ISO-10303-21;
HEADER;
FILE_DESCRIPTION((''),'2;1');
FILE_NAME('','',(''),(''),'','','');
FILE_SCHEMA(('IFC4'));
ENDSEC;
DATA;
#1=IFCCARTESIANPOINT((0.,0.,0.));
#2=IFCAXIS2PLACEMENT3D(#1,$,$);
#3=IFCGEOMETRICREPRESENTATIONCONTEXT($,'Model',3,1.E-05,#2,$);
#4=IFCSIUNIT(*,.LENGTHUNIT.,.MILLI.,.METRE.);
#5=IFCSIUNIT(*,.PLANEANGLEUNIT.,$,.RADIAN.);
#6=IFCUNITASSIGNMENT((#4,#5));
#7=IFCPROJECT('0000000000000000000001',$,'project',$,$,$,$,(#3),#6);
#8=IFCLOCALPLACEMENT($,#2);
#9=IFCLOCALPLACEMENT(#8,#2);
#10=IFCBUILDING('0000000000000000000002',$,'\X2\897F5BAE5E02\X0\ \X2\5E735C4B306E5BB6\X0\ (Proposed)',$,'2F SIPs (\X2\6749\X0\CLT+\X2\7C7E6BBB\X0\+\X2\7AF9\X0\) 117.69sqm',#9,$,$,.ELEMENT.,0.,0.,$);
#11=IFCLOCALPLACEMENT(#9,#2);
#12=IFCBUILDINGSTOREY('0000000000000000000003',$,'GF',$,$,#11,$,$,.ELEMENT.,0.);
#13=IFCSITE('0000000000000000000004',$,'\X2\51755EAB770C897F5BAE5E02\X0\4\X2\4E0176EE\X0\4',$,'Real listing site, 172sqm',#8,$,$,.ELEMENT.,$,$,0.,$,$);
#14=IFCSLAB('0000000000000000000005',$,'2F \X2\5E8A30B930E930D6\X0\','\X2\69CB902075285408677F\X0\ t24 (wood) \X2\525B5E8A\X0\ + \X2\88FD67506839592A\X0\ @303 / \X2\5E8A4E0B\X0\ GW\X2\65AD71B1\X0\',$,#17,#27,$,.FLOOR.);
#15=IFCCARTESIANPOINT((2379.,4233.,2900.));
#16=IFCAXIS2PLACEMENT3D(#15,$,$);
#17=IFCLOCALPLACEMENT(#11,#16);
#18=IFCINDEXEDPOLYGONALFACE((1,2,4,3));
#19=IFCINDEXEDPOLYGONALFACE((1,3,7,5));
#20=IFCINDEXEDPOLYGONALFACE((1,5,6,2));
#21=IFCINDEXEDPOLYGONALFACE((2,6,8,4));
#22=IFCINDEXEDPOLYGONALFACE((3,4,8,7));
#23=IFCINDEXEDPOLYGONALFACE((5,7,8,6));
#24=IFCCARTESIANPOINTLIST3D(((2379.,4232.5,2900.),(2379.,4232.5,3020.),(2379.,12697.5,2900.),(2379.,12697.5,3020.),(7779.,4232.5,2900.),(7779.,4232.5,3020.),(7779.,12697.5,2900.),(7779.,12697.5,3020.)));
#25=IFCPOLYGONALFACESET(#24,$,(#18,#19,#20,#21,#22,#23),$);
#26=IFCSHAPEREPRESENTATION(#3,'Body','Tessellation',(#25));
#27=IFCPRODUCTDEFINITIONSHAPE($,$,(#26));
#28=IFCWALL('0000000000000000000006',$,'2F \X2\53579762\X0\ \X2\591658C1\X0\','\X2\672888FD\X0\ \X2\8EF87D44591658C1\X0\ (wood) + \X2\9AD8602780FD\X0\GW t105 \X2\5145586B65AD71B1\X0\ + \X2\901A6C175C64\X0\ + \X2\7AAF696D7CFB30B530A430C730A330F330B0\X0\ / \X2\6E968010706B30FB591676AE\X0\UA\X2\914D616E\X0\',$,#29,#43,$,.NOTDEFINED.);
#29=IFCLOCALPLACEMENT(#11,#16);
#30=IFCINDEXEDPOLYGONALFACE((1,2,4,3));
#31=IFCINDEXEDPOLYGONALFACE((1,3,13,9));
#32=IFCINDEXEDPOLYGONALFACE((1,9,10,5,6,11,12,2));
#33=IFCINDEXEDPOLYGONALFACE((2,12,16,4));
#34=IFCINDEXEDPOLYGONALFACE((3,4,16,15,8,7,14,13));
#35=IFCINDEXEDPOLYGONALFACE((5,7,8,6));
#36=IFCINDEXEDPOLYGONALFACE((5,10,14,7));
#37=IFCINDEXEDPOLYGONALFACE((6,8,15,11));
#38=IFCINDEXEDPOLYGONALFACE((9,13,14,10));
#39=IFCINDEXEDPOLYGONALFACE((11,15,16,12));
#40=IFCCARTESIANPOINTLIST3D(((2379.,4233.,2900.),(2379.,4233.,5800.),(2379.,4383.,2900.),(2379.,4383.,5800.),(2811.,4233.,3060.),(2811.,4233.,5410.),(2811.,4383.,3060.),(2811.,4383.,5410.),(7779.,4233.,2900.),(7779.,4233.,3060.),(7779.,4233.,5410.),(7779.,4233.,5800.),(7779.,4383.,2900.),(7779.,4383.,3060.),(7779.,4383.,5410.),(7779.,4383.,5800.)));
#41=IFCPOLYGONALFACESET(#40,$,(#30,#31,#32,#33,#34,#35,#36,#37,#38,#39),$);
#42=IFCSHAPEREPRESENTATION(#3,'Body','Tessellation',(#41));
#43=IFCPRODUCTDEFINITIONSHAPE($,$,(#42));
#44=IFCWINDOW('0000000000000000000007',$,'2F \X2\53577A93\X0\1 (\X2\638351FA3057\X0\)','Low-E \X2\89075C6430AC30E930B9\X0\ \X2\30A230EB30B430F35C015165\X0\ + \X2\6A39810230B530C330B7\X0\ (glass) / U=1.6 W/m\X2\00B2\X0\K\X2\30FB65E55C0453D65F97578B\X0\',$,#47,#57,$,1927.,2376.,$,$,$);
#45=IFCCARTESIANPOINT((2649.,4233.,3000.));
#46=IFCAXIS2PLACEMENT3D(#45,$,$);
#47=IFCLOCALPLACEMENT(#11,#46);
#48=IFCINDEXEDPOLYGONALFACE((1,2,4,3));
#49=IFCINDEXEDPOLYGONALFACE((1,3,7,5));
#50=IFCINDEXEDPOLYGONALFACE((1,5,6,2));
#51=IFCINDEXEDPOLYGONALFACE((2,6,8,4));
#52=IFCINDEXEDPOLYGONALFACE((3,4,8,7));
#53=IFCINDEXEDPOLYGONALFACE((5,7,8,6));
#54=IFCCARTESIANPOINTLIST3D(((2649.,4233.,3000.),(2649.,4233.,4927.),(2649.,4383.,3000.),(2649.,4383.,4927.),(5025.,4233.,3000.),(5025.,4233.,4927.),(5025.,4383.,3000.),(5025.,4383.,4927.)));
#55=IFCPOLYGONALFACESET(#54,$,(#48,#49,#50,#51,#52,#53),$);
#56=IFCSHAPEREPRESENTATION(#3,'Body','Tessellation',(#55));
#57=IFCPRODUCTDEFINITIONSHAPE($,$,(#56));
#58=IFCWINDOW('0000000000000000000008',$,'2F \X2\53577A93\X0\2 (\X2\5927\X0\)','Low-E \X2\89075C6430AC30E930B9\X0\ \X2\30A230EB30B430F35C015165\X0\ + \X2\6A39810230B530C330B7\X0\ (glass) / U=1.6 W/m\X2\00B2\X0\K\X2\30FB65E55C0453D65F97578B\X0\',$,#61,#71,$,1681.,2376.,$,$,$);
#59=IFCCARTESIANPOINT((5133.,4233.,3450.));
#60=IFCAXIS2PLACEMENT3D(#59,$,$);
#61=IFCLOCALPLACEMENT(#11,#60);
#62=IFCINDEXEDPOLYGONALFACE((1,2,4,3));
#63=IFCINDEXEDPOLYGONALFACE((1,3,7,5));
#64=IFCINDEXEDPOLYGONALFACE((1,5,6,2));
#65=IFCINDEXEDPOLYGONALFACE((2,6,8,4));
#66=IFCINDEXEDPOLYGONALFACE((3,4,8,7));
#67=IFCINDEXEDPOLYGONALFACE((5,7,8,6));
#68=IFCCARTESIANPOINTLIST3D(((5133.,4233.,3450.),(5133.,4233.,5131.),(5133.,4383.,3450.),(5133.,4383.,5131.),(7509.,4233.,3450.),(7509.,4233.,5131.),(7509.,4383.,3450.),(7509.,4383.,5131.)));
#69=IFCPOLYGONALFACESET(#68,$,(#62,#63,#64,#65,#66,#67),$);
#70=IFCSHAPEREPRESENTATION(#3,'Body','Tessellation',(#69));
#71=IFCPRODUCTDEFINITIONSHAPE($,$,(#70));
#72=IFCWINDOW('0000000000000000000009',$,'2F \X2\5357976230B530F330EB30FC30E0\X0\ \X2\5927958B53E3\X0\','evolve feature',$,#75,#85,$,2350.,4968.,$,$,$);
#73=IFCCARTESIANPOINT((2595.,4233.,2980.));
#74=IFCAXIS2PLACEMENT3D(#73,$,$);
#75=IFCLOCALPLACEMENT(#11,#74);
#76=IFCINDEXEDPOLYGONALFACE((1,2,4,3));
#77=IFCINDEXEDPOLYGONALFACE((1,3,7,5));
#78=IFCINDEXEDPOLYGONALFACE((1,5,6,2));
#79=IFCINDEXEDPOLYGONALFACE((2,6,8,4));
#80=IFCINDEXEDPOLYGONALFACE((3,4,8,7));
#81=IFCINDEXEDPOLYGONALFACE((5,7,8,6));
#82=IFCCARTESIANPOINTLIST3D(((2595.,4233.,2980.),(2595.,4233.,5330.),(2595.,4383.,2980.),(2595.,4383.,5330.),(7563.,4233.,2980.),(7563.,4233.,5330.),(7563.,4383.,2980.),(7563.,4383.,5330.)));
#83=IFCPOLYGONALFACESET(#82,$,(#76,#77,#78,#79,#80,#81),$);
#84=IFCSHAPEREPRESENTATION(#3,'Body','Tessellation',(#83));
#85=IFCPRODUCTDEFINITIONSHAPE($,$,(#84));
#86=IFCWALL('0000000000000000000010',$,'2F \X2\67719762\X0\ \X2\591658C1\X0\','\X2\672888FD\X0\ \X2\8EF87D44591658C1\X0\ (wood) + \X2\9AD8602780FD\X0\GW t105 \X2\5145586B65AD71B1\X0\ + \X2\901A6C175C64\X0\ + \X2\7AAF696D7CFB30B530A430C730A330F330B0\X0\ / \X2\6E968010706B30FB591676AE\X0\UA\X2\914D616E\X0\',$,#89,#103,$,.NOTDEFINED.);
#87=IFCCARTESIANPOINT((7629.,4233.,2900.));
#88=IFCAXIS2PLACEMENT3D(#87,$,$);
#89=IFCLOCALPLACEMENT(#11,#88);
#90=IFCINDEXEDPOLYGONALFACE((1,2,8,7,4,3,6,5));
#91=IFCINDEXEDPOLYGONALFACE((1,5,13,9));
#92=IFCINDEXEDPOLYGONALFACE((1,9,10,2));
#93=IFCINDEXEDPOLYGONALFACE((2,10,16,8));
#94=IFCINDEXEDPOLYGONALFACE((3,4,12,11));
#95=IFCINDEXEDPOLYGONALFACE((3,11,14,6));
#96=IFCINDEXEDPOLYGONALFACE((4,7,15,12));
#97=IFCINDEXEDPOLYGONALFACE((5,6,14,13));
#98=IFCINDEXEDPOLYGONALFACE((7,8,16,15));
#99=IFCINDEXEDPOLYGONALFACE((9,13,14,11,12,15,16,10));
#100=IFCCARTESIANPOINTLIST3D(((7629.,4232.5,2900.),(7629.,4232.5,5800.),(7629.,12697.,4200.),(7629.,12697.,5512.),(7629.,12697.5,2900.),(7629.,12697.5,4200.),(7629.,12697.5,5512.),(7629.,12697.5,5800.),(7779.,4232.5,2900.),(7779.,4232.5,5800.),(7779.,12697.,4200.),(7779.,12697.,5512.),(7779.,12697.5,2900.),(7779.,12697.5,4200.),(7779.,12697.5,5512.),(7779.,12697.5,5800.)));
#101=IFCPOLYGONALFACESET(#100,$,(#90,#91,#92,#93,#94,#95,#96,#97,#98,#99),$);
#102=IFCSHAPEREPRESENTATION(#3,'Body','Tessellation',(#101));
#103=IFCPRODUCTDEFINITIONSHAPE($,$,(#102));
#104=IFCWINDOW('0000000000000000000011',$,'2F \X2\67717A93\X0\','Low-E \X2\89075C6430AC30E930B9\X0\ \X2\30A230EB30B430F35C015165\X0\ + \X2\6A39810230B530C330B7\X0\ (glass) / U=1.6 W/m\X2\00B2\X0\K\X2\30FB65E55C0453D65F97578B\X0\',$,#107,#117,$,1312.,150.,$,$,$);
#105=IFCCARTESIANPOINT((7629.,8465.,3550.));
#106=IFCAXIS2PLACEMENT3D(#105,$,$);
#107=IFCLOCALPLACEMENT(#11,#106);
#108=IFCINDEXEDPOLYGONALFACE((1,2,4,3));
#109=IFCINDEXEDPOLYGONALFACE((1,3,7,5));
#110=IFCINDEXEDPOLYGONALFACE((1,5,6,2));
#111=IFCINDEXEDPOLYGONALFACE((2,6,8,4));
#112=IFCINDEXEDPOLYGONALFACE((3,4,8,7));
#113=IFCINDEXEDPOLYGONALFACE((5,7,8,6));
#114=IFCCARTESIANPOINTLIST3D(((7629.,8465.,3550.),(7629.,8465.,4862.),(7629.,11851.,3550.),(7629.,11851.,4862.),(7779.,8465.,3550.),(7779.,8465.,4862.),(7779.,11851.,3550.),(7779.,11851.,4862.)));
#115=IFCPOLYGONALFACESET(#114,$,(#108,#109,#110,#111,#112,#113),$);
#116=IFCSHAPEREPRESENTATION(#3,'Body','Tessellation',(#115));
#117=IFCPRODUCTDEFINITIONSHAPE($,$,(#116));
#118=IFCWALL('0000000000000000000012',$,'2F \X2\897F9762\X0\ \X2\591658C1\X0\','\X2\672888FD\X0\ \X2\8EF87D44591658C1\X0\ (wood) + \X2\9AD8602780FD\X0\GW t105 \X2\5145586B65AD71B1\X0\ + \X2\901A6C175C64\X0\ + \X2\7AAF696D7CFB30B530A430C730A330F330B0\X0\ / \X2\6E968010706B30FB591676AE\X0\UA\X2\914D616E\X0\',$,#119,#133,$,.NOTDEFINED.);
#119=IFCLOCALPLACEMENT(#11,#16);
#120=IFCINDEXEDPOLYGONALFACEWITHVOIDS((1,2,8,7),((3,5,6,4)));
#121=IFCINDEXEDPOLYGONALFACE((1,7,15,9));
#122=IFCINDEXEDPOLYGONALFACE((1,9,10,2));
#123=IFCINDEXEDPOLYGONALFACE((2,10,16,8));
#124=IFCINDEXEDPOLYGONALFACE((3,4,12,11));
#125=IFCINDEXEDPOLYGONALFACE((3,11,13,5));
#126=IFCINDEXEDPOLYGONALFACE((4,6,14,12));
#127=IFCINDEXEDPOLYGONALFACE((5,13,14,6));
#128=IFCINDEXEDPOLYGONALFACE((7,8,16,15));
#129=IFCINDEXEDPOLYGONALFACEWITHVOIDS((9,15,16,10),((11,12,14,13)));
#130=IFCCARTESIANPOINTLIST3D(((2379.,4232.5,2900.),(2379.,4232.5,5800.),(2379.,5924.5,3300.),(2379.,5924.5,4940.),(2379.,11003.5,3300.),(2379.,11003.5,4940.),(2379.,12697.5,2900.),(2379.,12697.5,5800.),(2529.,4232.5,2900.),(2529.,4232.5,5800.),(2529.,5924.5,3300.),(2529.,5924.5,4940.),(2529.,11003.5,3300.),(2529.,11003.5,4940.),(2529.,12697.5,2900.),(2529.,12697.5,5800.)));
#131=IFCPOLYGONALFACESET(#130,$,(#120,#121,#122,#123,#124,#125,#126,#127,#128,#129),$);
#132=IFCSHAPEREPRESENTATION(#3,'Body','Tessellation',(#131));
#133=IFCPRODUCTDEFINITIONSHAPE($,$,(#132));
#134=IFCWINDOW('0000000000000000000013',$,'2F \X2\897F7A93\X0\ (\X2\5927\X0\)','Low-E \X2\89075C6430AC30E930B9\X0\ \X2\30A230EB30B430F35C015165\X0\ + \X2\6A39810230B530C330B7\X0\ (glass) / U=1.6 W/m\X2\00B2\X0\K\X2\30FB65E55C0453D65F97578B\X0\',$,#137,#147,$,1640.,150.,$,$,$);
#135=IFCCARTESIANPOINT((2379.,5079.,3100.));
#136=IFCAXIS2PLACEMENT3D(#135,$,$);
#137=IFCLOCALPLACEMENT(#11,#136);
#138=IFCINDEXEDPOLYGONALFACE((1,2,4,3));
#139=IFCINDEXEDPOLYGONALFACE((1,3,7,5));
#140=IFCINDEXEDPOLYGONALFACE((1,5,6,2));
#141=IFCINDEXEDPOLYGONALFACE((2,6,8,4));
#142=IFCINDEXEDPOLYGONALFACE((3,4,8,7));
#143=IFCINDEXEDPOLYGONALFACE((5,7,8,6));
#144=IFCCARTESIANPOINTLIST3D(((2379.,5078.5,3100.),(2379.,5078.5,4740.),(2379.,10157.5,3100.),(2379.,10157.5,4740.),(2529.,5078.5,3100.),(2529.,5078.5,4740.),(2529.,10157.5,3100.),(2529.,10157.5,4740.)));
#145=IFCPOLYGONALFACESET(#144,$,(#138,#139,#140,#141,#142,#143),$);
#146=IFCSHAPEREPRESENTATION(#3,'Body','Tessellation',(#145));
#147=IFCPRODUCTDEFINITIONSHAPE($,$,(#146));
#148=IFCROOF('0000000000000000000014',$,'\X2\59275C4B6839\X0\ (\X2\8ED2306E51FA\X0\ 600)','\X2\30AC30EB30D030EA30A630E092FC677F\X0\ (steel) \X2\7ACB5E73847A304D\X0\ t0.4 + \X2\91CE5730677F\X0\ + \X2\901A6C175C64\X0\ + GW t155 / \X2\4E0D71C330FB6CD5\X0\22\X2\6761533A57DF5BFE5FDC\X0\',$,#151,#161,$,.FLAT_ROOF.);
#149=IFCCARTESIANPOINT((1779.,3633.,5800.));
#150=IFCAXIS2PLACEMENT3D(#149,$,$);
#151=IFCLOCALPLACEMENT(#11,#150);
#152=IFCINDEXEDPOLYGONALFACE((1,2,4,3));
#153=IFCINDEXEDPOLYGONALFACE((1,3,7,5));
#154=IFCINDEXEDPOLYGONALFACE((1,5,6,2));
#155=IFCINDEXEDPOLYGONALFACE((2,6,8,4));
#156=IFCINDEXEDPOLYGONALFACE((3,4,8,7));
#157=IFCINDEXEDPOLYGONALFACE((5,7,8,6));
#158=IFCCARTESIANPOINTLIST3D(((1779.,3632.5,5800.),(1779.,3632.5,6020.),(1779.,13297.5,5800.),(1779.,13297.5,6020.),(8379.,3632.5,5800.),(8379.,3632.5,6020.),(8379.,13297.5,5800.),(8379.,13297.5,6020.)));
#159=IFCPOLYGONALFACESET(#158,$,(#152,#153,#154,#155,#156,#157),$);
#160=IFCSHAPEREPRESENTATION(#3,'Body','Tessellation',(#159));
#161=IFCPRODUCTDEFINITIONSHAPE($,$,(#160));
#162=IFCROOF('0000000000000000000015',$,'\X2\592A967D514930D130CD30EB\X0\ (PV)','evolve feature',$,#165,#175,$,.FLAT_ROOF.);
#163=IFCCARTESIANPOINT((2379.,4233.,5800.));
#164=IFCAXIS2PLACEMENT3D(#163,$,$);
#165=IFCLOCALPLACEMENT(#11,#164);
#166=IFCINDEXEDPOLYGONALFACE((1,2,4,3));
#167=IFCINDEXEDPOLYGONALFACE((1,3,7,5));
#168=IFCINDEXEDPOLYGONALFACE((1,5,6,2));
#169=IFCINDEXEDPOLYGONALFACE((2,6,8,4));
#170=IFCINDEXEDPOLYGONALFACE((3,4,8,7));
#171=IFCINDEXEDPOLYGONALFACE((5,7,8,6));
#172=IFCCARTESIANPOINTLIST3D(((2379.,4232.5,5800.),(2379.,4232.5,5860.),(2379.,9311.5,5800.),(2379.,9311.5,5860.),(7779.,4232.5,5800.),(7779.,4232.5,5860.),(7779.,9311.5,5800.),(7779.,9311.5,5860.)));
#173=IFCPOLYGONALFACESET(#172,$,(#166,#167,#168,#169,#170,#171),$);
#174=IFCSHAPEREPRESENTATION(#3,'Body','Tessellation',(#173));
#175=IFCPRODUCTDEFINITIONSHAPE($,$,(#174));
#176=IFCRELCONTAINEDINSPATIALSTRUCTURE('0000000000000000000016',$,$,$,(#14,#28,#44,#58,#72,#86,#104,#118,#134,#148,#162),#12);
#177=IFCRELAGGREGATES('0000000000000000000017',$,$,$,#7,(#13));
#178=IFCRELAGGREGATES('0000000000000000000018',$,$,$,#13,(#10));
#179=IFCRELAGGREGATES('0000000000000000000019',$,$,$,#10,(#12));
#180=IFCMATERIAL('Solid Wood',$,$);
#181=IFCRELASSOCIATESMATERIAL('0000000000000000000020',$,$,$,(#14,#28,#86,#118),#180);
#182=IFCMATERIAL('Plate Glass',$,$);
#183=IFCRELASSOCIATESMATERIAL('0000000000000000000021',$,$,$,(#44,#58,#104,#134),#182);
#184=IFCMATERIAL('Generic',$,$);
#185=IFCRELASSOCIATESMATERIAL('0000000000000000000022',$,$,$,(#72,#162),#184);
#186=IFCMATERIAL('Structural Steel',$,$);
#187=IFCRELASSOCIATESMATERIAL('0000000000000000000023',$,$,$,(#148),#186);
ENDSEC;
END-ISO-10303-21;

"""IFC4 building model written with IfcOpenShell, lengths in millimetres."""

from ifc_helpers import new_model, si_unit, frame, frame_2d, origin, place, context, project, spatial, rectangle, extrude, material, element, fill, save


model = new_model("IFC4")

# Units and contexts
model_context = context("Model", 3, precision=1e-05, world=origin())
ifc_project = project(units=[si_unit("LENGTHUNIT", "METRE", prefix="MILLI"), si_unit("PLANEANGLEUNIT", "RADIAN")], contexts=[model_context])

# Site, building, storey
site_placement = place(None, origin())
site = spatial("IfcSite", under=ifc_project, at=site_placement, Name="兵庫県西宮市4丁目4", ObjectType="Real listing site, 172sqm", CompositionType="ELEMENT", RefElevation=0.0)
building_placement = place(site_placement, origin())
building = spatial("IfcBuilding", under=site, at=building_placement, Name="西宮市 平屋の家 (Proposed)", ObjectType="2F SIPs (杉CLT+籾殻+竹) 117.69sqm", CompositionType="ELEMENT", ElevationOfRefHeight=0.0, ElevationOfTerrain=0.0)
storey_placement = place(building_placement, origin())
storey = spatial("IfcBuildingStorey", under=building, at=storey_placement, Name="GF", CompositionType="ELEMENT", Elevation=0.0)

# Slab
ifc_material_1 = material(Name="Solid Wood")
slab_placement = place(storey_placement, frame((2379.0, 4233.0, 2900.0)))
element("IfcSlab", 1, at=slab_placement, inside=storey, material=ifc_material_1, Name="2F 床スラブ", Description="構造用合板 t24 (wood) 剛床 + 製材根太 @303 / 床下 GW断熱", PredefinedType="FLOOR", context=model_context, shape_type="SweptSolid", body=[
    extrude(rectangle(XDim=5400.0, YDim=8465.0, at=frame_2d((2700.0, 4232.0))), frame((2379.0, 4233.0, 2900.0)), (0.0, 0.0, 1.0), 120.0),
])

# Wall, openings, windows
wall_1_placement = place(storey_placement, frame((2379.0, 4233.0, 2900.0)))
wall_1 = element("IfcWall", 2, at=wall_1_placement, inside=storey, material=ifc_material_1, Name="2F 南面 外壁", Description="木製 軸組外壁 (wood) + 高性能GW t105 充填断熱 + 通気層 + 窯業系サイディング / 準耐火・外皮UA配慮", PredefinedType="NOTDEFINED", context=model_context, shape_type="SweptSolid", body=[
    extrude(rectangle(XDim=5400.0, YDim=150.0, at=frame_2d((2700.0, 75.0))), frame((2379.0, 4233.0, 2900.0)), (0.0, 0.0, 1.0), 2900.0),
])
opening_1_placement = place(storey_placement, frame((2649.0, 4233.0, 3000.0)))
opening_1 = element("IfcOpeningElement", 3, at=opening_1_placement, cuts=wall_1, PredefinedType="NOTDEFINED", context=model_context, shape_type="SweptSolid", body=[
    extrude(rectangle(XDim=2376.0, YDim=150.0, at=frame_2d((1188.0, 75.0))), frame((2649.0, 4233.0, 3000.0)), (0.0, 0.0, 1.0), 1927.0),
])
opening_2_placement = place(storey_placement, frame((5133.0, 4233.0, 3450.0)))
opening_2 = element("IfcOpeningElement", 4, at=opening_2_placement, cuts=wall_1, PredefinedType="NOTDEFINED", context=model_context, shape_type="SweptSolid", body=[
    extrude(rectangle(XDim=2376.0, YDim=150.0, at=frame_2d((1188.0, 75.0))), frame((5133.0, 4233.0, 3450.0)), (0.0, 0.0, 1.0), 1681.0),
])
opening_3_placement = place(storey_placement, frame((2595.0, 4233.0, 2980.0)))
opening_3 = element("IfcOpeningElement", 5, at=opening_3_placement, cuts=wall_1, PredefinedType="NOTDEFINED", context=model_context, shape_type="SweptSolid", body=[
    extrude(rectangle(XDim=4968.0, YDim=150.0, at=frame_2d((2484.0, 75.0))), frame((2595.0, 4233.0, 2980.0)), (0.0, 0.0, 1.0), 2350.0),
])
ifc_material_2 = material(Name="Plate Glass")
window_1_placement = place(storey_placement, frame((2649.0, 4233.0, 3000.0)))
window_1 = element("IfcWindow", 6, at=window_1_placement, inside=storey, material=ifc_material_2, Name="2F 南窓1 (掃出し)", Description="Low-E 複層ガラス アルゴン封入 + 樹脂サッシ (glass) / U=1.6 W/m²K・日射取得型", OverallHeight=1927.0, OverallWidth=2376.0, context=model_context, shape_type="SweptSolid", body=[
    extrude(rectangle(XDim=2376.0, YDim=150.0, at=frame_2d((1188.0, 75.0))), frame((2649.0, 4233.0, 3000.0)), (0.0, 0.0, 1.0), 1927.0),
])
fill(opening_1, window_1)
window_2_placement = place(storey_placement, frame((5133.0, 4233.0, 3450.0)))
window_2 = element("IfcWindow", 7, at=window_2_placement, inside=storey, material=ifc_material_2, Name="2F 南窓2 (大)", Description="Low-E 複層ガラス アルゴン封入 + 樹脂サッシ (glass) / U=1.6 W/m²K・日射取得型", OverallHeight=1681.0, OverallWidth=2376.0, context=model_context, shape_type="SweptSolid", body=[
    extrude(rectangle(XDim=2376.0, YDim=150.0, at=frame_2d((1188.0, 75.0))), frame((5133.0, 4233.0, 3450.0)), (0.0, 0.0, 1.0), 1681.0),
])
fill(opening_2, window_2)
ifc_material_3 = material(Name="Generic")
window_3_placement = place(storey_placement, frame((2595.0, 4233.0, 2980.0)))
window_3 = element("IfcWindow", 8, at=window_3_placement, inside=storey, material=ifc_material_3, Name="2F 南面サンルーム 大開口", Description="evolve feature", OverallHeight=2350.0, OverallWidth=4968.0, context=model_context, shape_type="SweptSolid", body=[
    extrude(rectangle(XDim=4968.0, YDim=150.0, at=frame_2d((2484.0, 75.0))), frame((2595.0, 4233.0, 2980.0)), (0.0, 0.0, 1.0), 2350.0),
])
fill(opening_3, window_3)

# Walls, openings, windows
wall_2_placement = place(storey_placement, frame((7629.0, 4233.0, 2900.0)))
wall_2 = element("IfcWall", 9, at=wall_2_placement, inside=storey, material=ifc_material_1, Name="2F 東面 外壁", Description="木製 軸組外壁 (wood) + 高性能GW t105 充填断熱 + 通気層 + 窯業系サイディング / 準耐火・外皮UA配慮", PredefinedType="NOTDEFINED", context=model_context, shape_type="SweptSolid", body=[
    extrude(rectangle(XDim=150.0, YDim=8465.0, at=frame_2d((75.0, 4232.0))), frame((7629.0, 4233.0, 2900.0)), (0.0, 0.0, 1.0), 2900.0),
])
opening_4_placement = place(storey_placement, frame((7629.0, 8465.0, 3550.0)))
opening_4 = element("IfcOpeningElement", 10, at=opening_4_placement, cuts=wall_2, PredefinedType="NOTDEFINED", context=model_context, shape_type="SweptSolid", body=[
    extrude(rectangle(XDim=150.0, YDim=3386.0, at=frame_2d((75.0, 1693.0))), frame((7629.0, 8465.0, 3550.0)), (0.0, 0.0, 1.0), 1312.0),
])
window_4_placement = place(storey_placement, frame((7629.0, 8465.0, 3550.0)))
window_4 = element("IfcWindow", 11, at=window_4_placement, inside=storey, material=ifc_material_2, Name="2F 東窓", Description="Low-E 複層ガラス アルゴン封入 + 樹脂サッシ (glass) / U=1.6 W/m²K・日射取得型", OverallHeight=1312.0, OverallWidth=150.0, context=model_context, shape_type="SweptSolid", body=[
    extrude(rectangle(XDim=150.0, YDim=3386.0, at=frame_2d((75.0, 1693.0))), frame((7629.0, 8465.0, 3550.0)), (0.0, 0.0, 1.0), 1312.0),
])
fill(opening_4, window_4)
wall_3_placement = place(storey_placement, frame((2379.0, 4233.0, 2900.0)))
wall_3 = element("IfcWall", 12, at=wall_3_placement, inside=storey, material=ifc_material_1, Name="2F 西面 外壁", Description="木製 軸組外壁 (wood) + 高性能GW t105 充填断熱 + 通気層 + 窯業系サイディング / 準耐火・外皮UA配慮", PredefinedType="NOTDEFINED", context=model_context, shape_type="SweptSolid", body=[
    extrude(rectangle(XDim=150.0, YDim=8465.0, at=frame_2d((75.0, 4232.0))), frame((2379.0, 4233.0, 2900.0)), (0.0, 0.0, 1.0), 2900.0),
])
opening_5_placement = place(storey_placement, frame((2379.0, 5079.0, 3100.0)))
opening_5 = element("IfcOpeningElement", 13, at=opening_5_placement, cuts=wall_3, PredefinedType="NOTDEFINED", context=model_context, shape_type="SweptSolid", body=[
    extrude(rectangle(XDim=150.0, YDim=5079.0, at=frame_2d((75.0, 2539.0))), frame((2379.0, 5079.0, 3100.0)), (0.0, 0.0, 1.0), 1640.0),
])
window_5_placement = place(storey_placement, frame((2379.0, 5079.0, 3100.0)))
window_5 = element("IfcWindow", 14, at=window_5_placement, inside=storey, material=ifc_material_2, Name="2F 西窓 (大)", Description="Low-E 複層ガラス アルゴン封入 + 樹脂サッシ (glass) / U=1.6 W/m²K・日射取得型", OverallHeight=1640.0, OverallWidth=150.0, context=model_context, shape_type="SweptSolid", body=[
    extrude(rectangle(XDim=150.0, YDim=5079.0, at=frame_2d((75.0, 2539.0))), frame((2379.0, 5079.0, 3100.0)), (0.0, 0.0, 1.0), 1640.0),
])
fill(opening_5, window_5)

# Roofs
ifc_material_4 = material(Name="Structural Steel")
roof_1_placement = place(storey_placement, frame((1779.0, 3633.0, 5800.0)))
element("IfcRoof", 15, at=roof_1_placement, inside=storey, material=ifc_material_4, Name="大屋根 (軒の出 600)", Description="ガルバリウム鋼板 (steel) 立平葺き t0.4 + 野地板 + 通気層 + GW t155 / 不燃・法22条区域対応", PredefinedType="FLAT_ROOF", context=model_context, shape_type="SweptSolid", body=[
    extrude(rectangle(XDim=6600.0, YDim=9665.0, at=frame_2d((3300.0, 4832.0))), frame((1779.0, 3633.0, 5800.0)), (0.0, 0.0, 1.0), 220.0),
])
roof_2_placement = place(storey_placement, frame((2379.0, 4233.0, 5800.0)))
element("IfcRoof", 16, at=roof_2_placement, inside=storey, material=ifc_material_3, Name="太陽光パネル (PV)", Description="evolve feature", PredefinedType="FLAT_ROOF", context=model_context, shape_type="SweptSolid", body=[
    extrude(rectangle(XDim=5400.0, YDim=5079.0, at=frame_2d((2700.0, 2539.0))), frame((2379.0, 4233.0, 5800.0)), (0.0, 0.0, 1.0), 60.0),
])

save(model, "model.ifc")
